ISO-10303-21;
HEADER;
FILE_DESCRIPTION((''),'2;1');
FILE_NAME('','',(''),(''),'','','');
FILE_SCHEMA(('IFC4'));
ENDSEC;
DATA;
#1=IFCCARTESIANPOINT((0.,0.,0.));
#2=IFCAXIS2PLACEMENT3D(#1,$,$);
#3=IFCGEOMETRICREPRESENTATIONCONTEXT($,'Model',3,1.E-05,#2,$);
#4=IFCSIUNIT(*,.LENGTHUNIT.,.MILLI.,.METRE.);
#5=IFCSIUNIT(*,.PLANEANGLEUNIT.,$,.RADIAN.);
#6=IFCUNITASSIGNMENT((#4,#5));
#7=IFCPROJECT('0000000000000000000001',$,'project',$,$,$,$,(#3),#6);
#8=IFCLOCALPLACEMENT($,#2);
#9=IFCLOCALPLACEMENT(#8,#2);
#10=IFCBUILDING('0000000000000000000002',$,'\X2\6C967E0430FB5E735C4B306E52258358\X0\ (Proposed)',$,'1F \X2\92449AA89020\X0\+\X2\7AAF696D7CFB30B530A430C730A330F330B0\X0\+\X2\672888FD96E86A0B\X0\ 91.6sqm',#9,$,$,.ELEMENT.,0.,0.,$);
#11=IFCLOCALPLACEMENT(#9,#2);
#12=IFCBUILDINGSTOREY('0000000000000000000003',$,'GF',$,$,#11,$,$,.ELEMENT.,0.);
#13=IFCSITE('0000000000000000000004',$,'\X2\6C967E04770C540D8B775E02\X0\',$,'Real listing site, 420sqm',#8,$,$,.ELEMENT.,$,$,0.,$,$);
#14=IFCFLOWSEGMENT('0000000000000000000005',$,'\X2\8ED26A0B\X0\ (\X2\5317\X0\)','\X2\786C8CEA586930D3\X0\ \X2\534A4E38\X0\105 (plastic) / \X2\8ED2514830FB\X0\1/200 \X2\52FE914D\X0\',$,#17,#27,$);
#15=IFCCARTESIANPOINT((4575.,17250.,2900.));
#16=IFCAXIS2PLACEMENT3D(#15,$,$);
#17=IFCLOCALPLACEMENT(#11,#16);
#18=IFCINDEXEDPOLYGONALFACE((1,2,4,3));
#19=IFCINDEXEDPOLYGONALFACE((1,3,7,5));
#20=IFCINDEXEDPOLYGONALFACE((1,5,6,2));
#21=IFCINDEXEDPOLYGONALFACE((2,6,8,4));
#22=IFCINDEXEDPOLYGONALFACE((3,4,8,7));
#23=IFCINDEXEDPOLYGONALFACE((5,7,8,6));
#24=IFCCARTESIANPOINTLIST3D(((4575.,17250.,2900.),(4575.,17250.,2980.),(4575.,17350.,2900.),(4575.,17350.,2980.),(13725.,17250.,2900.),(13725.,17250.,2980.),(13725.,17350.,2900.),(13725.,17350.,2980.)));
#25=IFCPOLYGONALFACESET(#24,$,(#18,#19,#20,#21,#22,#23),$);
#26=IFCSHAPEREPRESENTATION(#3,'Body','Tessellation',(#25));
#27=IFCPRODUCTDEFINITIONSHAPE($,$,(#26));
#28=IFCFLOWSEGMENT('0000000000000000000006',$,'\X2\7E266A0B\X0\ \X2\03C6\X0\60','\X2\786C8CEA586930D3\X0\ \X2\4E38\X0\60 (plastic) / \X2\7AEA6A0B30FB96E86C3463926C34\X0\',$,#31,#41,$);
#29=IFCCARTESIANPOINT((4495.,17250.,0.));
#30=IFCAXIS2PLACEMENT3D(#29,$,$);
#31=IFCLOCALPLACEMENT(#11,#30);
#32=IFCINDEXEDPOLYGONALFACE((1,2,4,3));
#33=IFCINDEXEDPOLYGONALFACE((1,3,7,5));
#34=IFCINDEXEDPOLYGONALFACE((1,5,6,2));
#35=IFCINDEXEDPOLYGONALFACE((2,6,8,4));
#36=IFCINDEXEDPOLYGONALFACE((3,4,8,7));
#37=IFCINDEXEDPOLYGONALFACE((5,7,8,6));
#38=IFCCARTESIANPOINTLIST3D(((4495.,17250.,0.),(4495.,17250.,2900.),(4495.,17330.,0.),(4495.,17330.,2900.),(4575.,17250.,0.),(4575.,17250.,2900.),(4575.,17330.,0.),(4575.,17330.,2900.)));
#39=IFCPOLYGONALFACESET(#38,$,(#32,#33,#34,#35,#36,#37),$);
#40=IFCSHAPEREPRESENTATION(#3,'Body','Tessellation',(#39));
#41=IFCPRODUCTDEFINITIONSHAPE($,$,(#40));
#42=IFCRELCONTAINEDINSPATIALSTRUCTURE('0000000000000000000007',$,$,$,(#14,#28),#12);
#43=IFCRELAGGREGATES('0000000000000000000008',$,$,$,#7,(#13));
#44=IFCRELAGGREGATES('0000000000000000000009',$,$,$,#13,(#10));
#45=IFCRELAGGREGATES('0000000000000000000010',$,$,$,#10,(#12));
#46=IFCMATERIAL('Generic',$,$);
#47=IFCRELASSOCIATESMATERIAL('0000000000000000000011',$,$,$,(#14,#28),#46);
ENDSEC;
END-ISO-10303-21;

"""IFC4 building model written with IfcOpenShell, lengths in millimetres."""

from ifc_helpers import new_model, si_unit, frame, frame_2d, origin, place, context, project, spatial, rectangle, extrude, material, element, save


model = new_model("IFC4")

# Units and contexts
model_context = context("Model", 3, precision=1e-05, world=origin())
ifc_project = project(units=[si_unit("LENGTHUNIT", "METRE", prefix="MILLI"), si_unit("PLANEANGLEUNIT", "RADIAN")], contexts=[model_context])

# Site, building, storey
site_placement = place(None, origin())
site = spatial("IfcSite", under=ifc_project, at=site_placement, Name="沖縄県名護市", ObjectType="Real listing site, 420sqm", CompositionType="ELEMENT", RefElevation=0.0)
building_placement = place(site_placement, origin())
building = spatial("IfcBuilding", under=site, at=building_placement, Name="沖縄・平屋の別荘 (Proposed)", ObjectType="1F 鉄骨造+窯業系サイディング+木製雨樋 91.6sqm", CompositionType="ELEMENT", ElevationOfRefHeight=0.0, ElevationOfTerrain=0.0)
storey_placement = place(building_placement, origin())
storey = spatial("IfcBuildingStorey", under=building, at=storey_placement, Name="GF", CompositionType="ELEMENT", Elevation=0.0)

# Shared definitions
ifc_material_1 = material(Name="Generic")

# Flow segments
flow_segment_1_placement = place(storey_placement, frame((4575.0, 17250.0, 2900.0)))
element("IfcFlowSegment", 1, at=flow_segment_1_placement, inside=storey, material=ifc_material_1, Name="軒樋 (北)", Description="硬質塩ビ 半丸105 (plastic) / 軒先・1/200 勾配", context=model_context, shape_type="SweptSolid", body=[
    extrude(rectangle(XDim=9150.0, YDim=100.0, at=frame_2d((4575.0, 50.0))), frame((4575.0, 17250.0, 2900.0)), (0.0, 0.0, 1.0), 80.0),
])
flow_segment_2_placement = place(storey_placement, frame((4495.0, 17250.0, 0.0)))
element("IfcFlowSegment", 2, at=flow_segment_2_placement, inside=storey, material=ifc_material_1, Name="縦樋 φ60", Description="硬質塩ビ 丸60 (plastic) / 竪樋・雨水排水", context=model_context, shape_type="SweptSolid", body=[
    extrude(rectangle(XDim=80.0, YDim=80.0, at=frame_2d((40.0, 40.0))), frame((4495.0, 17250.0, 0.0)), (0.0, 0.0, 1.0), 2900.0),
])

save(model, "model.ifc")
